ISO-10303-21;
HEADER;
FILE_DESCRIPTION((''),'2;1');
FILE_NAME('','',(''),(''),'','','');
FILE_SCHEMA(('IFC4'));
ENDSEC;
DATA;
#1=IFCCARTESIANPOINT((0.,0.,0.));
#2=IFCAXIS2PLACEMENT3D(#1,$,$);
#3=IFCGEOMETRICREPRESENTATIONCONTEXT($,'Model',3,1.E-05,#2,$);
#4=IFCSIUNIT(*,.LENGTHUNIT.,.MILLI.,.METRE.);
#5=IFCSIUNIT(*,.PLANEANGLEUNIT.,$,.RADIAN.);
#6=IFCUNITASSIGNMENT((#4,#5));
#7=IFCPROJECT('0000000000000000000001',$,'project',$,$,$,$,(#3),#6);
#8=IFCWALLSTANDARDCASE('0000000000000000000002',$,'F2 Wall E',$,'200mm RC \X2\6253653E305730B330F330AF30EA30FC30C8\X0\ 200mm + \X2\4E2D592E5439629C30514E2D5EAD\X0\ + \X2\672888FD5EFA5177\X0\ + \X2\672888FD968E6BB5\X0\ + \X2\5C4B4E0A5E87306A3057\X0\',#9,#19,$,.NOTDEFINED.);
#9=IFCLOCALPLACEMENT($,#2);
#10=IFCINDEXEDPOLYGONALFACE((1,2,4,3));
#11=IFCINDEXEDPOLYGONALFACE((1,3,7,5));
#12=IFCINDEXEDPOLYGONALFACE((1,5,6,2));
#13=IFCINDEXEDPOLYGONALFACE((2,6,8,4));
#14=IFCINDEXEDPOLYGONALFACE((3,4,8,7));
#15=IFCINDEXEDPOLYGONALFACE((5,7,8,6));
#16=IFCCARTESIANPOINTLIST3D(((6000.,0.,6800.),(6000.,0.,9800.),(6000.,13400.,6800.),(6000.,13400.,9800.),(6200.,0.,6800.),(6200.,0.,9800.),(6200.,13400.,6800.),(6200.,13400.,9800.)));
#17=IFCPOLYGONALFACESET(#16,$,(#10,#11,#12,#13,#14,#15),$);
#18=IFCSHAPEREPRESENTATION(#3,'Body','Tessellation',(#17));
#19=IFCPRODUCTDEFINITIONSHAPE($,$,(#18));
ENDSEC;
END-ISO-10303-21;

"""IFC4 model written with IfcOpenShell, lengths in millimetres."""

from ifc_helpers import new_model, si_unit, frame, frame_2d, origin, place, context, project, rectangle, extrude, element, save


model = new_model("IFC4")

# Units and contexts
model_context = context("Model", 3, precision=1e-05, world=origin())
ifc_project = project(units=[si_unit("LENGTHUNIT", "METRE", prefix="MILLI"), si_unit("PLANEANGLEUNIT", "RADIAN")], contexts=[model_context])

# Shared definitions
placement_1 = place(None, origin())
placement_2 = place(placement_1, origin())
placement_3 = place(placement_2, origin())

# Wall
wall_1_placement = place(placement_3, frame((3000.0, 0.0, 3400.0)))
element("IfcWallStandardCase", 1, at=wall_1_placement, Name="F2 Wall E", ObjectType="200mm RC 打放しコンクリート 200mm + 中央吹抜け中庭 + 木製建具 + 木製階段 + 屋上庇なし", PredefinedType="NOTDEFINED", context=model_context, shape_type="SweptSolid", body=[
    extrude(rectangle(XDim=200.0, YDim=13400.0, at=frame_2d((100.0, 6700.0))), frame((3000.0, 0.0, 3400.0)), (0.0, 0.0, 1.0), 3000.0),
])

save(model, "model.ifc")
